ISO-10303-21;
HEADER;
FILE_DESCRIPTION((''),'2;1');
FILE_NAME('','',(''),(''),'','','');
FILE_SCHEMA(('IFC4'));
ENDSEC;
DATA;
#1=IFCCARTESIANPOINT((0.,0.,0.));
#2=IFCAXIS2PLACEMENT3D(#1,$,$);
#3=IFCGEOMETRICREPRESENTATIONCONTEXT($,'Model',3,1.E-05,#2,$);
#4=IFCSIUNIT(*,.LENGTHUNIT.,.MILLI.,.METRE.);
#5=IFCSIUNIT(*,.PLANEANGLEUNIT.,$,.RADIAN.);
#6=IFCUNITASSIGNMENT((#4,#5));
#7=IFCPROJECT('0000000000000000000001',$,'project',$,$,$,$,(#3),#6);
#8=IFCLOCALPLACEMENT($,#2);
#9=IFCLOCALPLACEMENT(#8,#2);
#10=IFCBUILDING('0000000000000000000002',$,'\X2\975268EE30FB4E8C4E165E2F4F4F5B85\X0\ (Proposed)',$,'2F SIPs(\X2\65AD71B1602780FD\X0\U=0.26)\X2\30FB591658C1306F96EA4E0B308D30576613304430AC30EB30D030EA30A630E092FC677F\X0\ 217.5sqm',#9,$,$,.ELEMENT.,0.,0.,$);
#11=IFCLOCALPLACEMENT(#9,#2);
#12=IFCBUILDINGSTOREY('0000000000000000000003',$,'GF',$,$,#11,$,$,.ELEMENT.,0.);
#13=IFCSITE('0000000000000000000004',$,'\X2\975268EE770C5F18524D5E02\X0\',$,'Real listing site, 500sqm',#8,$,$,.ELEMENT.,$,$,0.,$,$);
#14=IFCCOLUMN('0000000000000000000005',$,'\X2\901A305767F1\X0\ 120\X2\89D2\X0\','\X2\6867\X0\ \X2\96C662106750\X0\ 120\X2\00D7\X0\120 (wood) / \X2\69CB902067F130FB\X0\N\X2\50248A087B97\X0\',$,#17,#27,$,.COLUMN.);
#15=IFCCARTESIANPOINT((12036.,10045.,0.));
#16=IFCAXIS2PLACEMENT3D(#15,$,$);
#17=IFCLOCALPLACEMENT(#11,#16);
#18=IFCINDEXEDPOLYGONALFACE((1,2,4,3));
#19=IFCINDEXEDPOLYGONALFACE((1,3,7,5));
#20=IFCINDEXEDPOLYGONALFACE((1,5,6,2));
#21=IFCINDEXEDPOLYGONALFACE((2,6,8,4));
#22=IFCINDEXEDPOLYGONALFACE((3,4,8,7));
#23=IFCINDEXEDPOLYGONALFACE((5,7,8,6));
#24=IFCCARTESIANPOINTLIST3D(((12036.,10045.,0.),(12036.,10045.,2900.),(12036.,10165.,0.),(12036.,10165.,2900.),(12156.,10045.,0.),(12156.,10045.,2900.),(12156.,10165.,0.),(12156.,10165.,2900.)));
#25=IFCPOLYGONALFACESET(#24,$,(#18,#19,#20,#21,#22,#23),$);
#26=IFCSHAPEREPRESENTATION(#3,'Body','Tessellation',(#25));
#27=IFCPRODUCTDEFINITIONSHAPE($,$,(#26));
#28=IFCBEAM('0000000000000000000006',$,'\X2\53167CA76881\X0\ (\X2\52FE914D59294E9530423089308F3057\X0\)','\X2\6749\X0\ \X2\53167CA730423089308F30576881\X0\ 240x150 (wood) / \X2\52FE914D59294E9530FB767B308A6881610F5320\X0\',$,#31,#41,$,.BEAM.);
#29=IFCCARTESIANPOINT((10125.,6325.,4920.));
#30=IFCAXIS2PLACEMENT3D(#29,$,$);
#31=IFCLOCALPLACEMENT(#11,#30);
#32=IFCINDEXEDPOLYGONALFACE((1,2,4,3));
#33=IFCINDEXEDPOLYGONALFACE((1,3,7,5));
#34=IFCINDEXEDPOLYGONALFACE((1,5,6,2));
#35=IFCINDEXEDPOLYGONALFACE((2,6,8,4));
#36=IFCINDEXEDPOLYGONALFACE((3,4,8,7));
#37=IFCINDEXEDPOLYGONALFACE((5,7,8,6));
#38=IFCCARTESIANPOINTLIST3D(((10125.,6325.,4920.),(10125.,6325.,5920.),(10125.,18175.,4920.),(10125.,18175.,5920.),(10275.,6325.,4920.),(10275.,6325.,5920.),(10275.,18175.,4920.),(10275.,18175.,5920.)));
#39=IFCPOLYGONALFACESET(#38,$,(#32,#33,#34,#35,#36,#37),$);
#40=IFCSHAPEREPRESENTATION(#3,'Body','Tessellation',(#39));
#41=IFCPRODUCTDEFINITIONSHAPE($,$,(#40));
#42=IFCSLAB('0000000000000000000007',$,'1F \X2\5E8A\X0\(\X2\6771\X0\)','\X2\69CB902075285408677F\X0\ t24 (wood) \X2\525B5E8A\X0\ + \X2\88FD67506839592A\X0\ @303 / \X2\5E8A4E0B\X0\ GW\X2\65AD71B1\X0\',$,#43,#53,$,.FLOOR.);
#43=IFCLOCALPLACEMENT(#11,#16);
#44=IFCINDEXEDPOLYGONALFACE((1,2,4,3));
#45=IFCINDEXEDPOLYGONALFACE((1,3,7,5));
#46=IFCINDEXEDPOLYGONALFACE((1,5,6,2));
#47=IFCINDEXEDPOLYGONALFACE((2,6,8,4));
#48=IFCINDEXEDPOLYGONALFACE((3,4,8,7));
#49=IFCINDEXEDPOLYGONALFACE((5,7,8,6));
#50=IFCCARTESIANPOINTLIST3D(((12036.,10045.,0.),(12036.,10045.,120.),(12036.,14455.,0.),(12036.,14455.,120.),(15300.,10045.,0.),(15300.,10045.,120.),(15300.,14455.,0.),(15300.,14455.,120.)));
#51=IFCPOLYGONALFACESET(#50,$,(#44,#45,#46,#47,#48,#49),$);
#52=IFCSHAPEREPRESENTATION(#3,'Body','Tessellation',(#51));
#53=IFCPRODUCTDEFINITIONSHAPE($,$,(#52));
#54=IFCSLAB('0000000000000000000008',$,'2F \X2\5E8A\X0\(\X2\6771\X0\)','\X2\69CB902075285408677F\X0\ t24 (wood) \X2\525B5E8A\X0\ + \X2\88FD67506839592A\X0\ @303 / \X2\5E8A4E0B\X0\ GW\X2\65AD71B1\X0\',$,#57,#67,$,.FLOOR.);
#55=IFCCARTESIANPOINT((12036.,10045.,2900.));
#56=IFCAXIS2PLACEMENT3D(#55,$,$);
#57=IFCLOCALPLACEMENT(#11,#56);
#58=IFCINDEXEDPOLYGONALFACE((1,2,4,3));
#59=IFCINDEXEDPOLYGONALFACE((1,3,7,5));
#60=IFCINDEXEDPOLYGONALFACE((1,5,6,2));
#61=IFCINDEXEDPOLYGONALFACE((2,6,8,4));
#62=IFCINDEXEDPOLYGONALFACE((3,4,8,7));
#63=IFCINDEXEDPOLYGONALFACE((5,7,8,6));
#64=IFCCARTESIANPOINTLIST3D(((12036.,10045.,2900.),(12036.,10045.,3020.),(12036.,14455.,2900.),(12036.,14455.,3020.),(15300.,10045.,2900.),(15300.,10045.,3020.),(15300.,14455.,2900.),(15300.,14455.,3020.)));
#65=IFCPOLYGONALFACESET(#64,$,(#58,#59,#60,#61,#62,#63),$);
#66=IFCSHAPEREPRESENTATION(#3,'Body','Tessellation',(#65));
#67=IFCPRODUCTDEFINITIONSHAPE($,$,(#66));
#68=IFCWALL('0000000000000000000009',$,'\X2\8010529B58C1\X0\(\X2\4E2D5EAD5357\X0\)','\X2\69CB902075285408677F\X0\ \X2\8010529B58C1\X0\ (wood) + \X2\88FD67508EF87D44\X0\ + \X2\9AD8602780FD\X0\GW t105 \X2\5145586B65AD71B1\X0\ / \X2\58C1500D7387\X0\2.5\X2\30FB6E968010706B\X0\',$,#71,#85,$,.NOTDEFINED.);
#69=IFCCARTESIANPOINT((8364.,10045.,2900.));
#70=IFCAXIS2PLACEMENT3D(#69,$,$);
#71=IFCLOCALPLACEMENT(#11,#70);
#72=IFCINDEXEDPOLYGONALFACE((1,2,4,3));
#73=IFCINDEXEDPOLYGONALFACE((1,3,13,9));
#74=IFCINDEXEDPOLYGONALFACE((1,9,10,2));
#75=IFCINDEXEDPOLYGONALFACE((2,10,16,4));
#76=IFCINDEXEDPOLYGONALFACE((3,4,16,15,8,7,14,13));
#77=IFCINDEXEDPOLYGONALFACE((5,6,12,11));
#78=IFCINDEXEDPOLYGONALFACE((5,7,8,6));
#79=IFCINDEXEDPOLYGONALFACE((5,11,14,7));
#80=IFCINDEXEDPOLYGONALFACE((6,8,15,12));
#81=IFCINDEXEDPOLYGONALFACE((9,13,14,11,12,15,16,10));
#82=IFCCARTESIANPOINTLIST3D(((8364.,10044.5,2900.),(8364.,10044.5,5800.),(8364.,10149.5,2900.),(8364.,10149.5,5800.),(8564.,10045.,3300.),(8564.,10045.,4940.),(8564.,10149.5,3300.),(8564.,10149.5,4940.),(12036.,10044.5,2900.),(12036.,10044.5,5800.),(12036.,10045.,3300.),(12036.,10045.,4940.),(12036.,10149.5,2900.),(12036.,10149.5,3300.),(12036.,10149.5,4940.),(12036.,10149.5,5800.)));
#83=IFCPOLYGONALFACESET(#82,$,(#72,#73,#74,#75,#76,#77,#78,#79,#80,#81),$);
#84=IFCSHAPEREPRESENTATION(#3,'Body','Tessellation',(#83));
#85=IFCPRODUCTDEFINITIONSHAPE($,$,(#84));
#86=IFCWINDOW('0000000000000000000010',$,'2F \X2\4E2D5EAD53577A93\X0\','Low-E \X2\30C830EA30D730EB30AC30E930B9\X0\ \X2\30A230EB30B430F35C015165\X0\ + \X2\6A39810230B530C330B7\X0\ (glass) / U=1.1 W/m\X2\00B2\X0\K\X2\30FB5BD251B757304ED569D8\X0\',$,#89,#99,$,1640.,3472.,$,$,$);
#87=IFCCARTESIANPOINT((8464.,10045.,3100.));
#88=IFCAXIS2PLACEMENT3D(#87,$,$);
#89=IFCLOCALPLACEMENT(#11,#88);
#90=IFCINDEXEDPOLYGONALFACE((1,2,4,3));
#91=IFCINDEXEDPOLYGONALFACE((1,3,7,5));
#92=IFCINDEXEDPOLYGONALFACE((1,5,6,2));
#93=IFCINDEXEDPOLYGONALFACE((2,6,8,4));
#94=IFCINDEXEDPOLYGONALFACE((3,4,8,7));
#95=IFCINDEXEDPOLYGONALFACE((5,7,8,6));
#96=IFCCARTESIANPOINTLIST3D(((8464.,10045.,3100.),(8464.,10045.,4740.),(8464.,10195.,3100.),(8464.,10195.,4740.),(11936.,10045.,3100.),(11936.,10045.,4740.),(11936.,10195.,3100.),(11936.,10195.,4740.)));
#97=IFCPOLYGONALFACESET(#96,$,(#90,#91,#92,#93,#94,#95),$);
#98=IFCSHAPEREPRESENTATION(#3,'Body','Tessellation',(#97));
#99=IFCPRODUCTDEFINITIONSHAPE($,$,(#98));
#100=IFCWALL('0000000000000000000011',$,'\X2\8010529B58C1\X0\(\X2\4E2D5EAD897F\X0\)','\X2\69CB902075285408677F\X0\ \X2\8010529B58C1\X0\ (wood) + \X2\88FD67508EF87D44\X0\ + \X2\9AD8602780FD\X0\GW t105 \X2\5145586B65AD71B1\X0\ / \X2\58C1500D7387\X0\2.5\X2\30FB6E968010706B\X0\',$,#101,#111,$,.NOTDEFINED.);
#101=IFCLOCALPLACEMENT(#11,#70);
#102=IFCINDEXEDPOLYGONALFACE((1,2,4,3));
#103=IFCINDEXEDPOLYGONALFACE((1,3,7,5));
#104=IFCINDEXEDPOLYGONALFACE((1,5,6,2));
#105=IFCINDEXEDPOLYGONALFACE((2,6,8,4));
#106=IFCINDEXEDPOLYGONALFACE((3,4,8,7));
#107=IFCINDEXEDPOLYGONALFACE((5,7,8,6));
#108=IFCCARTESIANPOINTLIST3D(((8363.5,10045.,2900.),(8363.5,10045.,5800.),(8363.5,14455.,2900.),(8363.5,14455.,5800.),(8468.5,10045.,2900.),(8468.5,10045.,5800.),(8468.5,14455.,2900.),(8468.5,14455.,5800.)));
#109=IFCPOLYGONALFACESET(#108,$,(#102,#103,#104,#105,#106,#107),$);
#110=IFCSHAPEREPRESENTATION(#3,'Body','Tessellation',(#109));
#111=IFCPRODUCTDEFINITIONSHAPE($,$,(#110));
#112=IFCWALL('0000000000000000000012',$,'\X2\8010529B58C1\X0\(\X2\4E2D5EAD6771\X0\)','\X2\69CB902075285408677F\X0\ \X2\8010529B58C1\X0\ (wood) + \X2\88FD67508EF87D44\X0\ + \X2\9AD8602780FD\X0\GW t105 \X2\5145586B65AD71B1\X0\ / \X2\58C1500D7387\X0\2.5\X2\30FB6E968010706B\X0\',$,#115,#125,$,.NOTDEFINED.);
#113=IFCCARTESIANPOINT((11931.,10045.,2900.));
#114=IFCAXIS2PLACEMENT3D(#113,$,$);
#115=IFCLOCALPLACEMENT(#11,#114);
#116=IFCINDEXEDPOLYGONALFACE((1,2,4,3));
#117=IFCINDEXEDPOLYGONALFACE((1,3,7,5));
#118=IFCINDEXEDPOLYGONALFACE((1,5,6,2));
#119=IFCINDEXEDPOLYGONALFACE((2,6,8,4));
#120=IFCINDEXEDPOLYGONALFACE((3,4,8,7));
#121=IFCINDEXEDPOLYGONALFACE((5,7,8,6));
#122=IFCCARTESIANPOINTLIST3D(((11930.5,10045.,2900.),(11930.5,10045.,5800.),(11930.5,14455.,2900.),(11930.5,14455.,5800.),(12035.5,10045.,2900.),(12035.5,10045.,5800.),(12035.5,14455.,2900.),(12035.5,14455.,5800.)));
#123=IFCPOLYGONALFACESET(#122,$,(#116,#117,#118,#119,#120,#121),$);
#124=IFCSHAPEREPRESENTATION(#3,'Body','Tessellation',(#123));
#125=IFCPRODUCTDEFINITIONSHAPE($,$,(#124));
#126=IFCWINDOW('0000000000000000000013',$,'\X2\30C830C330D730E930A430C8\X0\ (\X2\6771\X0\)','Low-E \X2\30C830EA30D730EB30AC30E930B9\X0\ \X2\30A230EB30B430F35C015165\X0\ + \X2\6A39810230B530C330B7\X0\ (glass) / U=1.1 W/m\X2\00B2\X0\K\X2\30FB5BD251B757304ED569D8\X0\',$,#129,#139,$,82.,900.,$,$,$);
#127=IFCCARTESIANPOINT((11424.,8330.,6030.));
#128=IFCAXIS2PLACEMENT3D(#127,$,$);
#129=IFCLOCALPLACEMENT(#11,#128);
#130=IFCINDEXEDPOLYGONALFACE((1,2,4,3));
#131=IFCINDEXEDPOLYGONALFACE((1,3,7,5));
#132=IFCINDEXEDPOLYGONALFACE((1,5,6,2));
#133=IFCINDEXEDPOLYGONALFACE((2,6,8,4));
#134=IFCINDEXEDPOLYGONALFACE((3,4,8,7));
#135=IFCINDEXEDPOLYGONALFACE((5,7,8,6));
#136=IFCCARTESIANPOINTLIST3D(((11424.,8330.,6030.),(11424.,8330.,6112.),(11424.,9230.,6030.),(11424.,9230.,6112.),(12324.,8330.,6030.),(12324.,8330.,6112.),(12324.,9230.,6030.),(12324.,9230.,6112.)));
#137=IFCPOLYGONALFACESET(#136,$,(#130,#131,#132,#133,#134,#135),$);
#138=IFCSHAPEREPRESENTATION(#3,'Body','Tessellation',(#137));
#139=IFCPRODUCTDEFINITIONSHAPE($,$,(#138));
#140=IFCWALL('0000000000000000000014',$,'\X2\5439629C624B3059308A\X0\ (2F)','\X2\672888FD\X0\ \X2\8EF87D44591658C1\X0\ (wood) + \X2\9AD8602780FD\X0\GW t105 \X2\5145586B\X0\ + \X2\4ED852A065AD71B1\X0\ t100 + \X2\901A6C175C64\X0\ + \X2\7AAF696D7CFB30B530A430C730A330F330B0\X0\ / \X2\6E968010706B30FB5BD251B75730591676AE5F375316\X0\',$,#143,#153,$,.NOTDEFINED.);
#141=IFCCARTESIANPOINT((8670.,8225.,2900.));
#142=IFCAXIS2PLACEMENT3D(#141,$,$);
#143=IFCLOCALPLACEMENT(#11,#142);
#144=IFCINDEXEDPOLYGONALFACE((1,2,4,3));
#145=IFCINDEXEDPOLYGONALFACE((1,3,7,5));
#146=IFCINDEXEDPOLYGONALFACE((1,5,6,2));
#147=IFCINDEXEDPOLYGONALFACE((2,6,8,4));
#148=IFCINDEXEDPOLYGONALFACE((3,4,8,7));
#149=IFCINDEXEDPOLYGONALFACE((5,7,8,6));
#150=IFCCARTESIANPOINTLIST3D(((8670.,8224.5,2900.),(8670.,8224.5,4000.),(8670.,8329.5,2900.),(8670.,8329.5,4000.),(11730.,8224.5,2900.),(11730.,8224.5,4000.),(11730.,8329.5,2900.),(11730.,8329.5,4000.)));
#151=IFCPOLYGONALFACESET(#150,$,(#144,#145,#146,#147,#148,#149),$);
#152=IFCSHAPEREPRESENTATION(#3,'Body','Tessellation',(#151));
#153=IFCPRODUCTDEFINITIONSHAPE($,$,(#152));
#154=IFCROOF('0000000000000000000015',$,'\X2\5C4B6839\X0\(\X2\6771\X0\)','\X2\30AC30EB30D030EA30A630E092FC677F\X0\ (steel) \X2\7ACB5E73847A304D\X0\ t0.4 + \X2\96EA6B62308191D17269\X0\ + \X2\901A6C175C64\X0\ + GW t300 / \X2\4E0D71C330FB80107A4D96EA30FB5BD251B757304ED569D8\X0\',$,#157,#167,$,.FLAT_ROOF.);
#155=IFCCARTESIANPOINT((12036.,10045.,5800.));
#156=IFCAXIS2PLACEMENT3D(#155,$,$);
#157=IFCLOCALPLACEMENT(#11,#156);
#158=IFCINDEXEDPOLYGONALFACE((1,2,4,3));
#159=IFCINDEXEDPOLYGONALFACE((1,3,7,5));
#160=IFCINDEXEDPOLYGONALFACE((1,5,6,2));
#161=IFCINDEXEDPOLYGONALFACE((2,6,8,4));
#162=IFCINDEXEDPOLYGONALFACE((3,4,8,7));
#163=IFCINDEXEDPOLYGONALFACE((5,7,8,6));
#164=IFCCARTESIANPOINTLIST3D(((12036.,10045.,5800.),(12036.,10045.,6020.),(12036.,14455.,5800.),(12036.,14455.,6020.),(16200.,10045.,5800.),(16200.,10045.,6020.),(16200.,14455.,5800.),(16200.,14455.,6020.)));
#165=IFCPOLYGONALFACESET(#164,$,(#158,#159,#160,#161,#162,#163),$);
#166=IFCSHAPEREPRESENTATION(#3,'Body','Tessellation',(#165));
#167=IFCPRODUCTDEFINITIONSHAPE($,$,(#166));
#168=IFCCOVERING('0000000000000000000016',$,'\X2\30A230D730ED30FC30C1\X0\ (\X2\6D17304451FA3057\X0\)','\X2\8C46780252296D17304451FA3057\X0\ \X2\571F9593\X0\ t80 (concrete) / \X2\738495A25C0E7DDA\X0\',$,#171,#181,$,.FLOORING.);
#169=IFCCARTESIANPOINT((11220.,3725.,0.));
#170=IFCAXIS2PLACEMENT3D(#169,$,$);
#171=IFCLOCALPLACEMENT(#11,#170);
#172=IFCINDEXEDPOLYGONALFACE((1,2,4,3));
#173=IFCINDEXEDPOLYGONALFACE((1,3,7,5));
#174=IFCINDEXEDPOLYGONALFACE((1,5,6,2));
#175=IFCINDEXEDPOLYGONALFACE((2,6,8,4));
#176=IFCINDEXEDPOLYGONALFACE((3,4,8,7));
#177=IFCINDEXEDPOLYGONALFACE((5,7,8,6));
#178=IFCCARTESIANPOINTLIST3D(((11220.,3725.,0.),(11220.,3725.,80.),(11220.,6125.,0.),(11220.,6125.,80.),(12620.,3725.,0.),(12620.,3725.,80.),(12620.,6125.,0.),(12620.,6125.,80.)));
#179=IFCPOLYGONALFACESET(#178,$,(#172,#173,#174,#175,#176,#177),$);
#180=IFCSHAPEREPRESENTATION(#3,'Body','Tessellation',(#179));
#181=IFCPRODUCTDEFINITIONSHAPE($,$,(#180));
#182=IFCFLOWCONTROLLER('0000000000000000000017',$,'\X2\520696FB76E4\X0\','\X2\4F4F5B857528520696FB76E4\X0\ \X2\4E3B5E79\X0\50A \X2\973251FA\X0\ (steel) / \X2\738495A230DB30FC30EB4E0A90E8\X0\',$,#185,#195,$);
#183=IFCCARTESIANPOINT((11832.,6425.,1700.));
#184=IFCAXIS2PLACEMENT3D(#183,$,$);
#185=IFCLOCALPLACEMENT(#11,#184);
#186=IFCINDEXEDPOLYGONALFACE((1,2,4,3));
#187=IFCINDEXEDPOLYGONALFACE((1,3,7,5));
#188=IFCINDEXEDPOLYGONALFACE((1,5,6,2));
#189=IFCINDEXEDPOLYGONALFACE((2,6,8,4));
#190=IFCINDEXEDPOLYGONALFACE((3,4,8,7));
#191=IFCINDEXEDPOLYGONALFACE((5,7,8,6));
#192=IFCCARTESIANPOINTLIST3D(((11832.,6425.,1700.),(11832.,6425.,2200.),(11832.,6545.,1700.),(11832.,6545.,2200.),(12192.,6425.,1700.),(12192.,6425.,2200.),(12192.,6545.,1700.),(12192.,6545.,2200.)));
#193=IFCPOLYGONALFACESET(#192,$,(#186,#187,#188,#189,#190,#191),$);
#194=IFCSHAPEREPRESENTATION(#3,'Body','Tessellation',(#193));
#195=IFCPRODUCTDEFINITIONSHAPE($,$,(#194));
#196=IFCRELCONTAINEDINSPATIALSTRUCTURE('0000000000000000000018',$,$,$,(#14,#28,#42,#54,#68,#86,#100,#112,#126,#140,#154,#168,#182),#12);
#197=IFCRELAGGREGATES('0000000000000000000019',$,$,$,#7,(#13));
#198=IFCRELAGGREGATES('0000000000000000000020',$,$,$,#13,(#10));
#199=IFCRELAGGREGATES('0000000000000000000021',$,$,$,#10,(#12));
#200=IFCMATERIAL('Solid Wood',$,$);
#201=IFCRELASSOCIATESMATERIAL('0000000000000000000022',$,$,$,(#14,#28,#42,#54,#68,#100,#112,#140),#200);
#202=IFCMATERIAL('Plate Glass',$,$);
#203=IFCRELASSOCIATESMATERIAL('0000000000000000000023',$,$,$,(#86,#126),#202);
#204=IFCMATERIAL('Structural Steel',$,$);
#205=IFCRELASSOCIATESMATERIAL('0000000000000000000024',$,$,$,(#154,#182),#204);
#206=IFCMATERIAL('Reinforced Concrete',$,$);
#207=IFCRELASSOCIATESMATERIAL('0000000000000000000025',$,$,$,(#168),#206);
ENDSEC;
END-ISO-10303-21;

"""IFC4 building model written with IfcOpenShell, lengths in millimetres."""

from ifc_helpers import new_model, si_unit, frame, frame_2d, origin, place, context, project, spatial, rectangle, extrude, material, element, fill, save


model = new_model("IFC4")

# Units and contexts
model_context = context("Model", 3, precision=1e-05, world=origin())
ifc_project = project(units=[si_unit("LENGTHUNIT", "METRE", prefix="MILLI"), si_unit("PLANEANGLEUNIT", "RADIAN")], contexts=[model_context])

# Site, building, storey
site_placement = place(None, origin())
site = spatial("IfcSite", under=ifc_project, at=site_placement, Name="青森県弘前市", ObjectType="Real listing site, 500sqm", CompositionType="ELEMENT", RefElevation=0.0)
building_placement = place(site_placement, origin())
building = spatial("IfcBuilding", under=site, at=building_placement, Name="青森・二世帯住宅 (Proposed)", ObjectType="2F SIPs(断熱性能U=0.26)・外壁は雪下ろし易いガルバリウム鋼板 217.5sqm", CompositionType="ELEMENT", ElevationOfRefHeight=0.0, ElevationOfTerrain=0.0)
storey_placement = place(building_placement, origin())
storey = spatial("IfcBuildingStorey", under=building, at=storey_placement, Name="GF", CompositionType="ELEMENT", Elevation=0.0)

# Column
ifc_material_1 = material(Name="Solid Wood")
column_1_placement = place(storey_placement, frame((12036.0, 10045.0, 0.0)))
element("IfcColumn", 1, at=column_1_placement, inside=storey, material=ifc_material_1, Name="通し柱 120角", Description="桧 集成材 120×120 (wood) / 構造柱・N値計算", PredefinedType="COLUMN", context=model_context, shape_type="SweptSolid", body=[
    extrude(rectangle(XDim=120.0, YDim=120.0, at=frame_2d((60.0, 60.0))), frame((12036.0, 10045.0, 0.0)), (0.0, 0.0, 1.0), 2900.0),
])

# Beam
beam_placement = place(storey_placement, frame((10125.0, 6325.0, 4920.0)))
element("IfcBeam", 2, at=beam_placement, inside=storey, material=ifc_material_1, Name="化粧梁 (勾配天井あらわし)", Description="杉 化粧あらわし梁 240x150 (wood) / 勾配天井・登り梁意匠", PredefinedType="BEAM", context=model_context, shape_type="SweptSolid", body=[
    extrude(rectangle(XDim=150.0, YDim=11850.0, at=frame_2d((75.0, 5925.0))), frame((10125.0, 6325.0, 4920.0)), (0.0, 0.0, 1.0), 1000.0),
])

# Slabs
slab_1_placement = place(storey_placement, frame((12036.0, 10045.0, 0.0)))
element("IfcSlab", 3, at=slab_1_placement, inside=storey, material=ifc_material_1, Name="1F 床(東)", Description="構造用合板 t24 (wood) 剛床 + 製材根太 @303 / 床下 GW断熱", PredefinedType="FLOOR", context=model_context, shape_type="SweptSolid", body=[
    extrude(rectangle(XDim=3264.0, YDim=4410.0, at=frame_2d((1632.0, 2205.0))), frame((12036.0, 10045.0, 0.0)), (0.0, 0.0, 1.0), 120.0),
])
slab_2_placement = place(storey_placement, frame((12036.0, 10045.0, 2900.0)))
element("IfcSlab", 4, at=slab_2_placement, inside=storey, material=ifc_material_1, Name="2F 床(東)", Description="構造用合板 t24 (wood) 剛床 + 製材根太 @303 / 床下 GW断熱", PredefinedType="FLOOR", context=model_context, shape_type="SweptSolid", body=[
    extrude(rectangle(XDim=3264.0, YDim=4410.0, at=frame_2d((1632.0, 2205.0))), frame((12036.0, 10045.0, 2900.0)), (0.0, 0.0, 1.0), 120.0),
])

# Wall, opening, window
wall_1_placement = place(storey_placement, frame((8364.0, 10045.0, 2900.0)))
wall_1 = element("IfcWall", 5, at=wall_1_placement, inside=storey, material=ifc_material_1, Name="耐力壁(中庭南)", Description="構造用合板 耐力壁 (wood) + 製材軸組 + 高性能GW t105 充填断熱 / 壁倍率2.5・準耐火", PredefinedType="NOTDEFINED", context=model_context, shape_type="SweptSolid", body=[
    extrude(rectangle(XDim=3672.0, YDim=105.0, at=frame_2d((1836.0, 52.0))), frame((8364.0, 10045.0, 2900.0)), (0.0, 0.0, 1.0), 2900.0),
])
opening_placement = place(storey_placement, frame((8464.0, 10045.0, 3100.0)))
opening = element("IfcOpeningElement", 6, at=opening_placement, cuts=wall_1, PredefinedType="NOTDEFINED", context=model_context, shape_type="SweptSolid", body=[
    extrude(rectangle(XDim=3472.0, YDim=150.0, at=frame_2d((1736.0, 75.0))), frame((8464.0, 10045.0, 3100.0)), (0.0, 0.0, 1.0), 1640.0),
])
ifc_material_2 = material(Name="Plate Glass")
window_1_placement = place(storey_placement, frame((8464.0, 10045.0, 3100.0)))
window_1 = element("IfcWindow", 7, at=window_1_placement, inside=storey, material=ifc_material_2, Name="2F 中庭南窓", Description="Low-E トリプルガラス アルゴン封入 + 樹脂サッシ (glass) / U=1.1 W/m²K・寒冷地仕様", OverallHeight=1640.0, OverallWidth=3472.0, context=model_context, shape_type="SweptSolid", body=[
    extrude(rectangle(XDim=3472.0, YDim=150.0, at=frame_2d((1736.0, 75.0))), frame((8464.0, 10045.0, 3100.0)), (0.0, 0.0, 1.0), 1640.0),
])
fill(opening, window_1)

# Walls
wall_2_placement = place(storey_placement, frame((8364.0, 10045.0, 2900.0)))
element("IfcWall", 8, at=wall_2_placement, inside=storey, material=ifc_material_1, Name="耐力壁(中庭西)", Description="構造用合板 耐力壁 (wood) + 製材軸組 + 高性能GW t105 充填断熱 / 壁倍率2.5・準耐火", PredefinedType="NOTDEFINED", context=model_context, shape_type="SweptSolid", body=[
    extrude(rectangle(XDim=105.0, YDim=4410.0, at=frame_2d((52.0, 2205.0))), frame((8364.0, 10045.0, 2900.0)), (0.0, 0.0, 1.0), 2900.0),
])
wall_3_placement = place(storey_placement, frame((11931.0, 10045.0, 2900.0)))
element("IfcWall", 9, at=wall_3_placement, inside=storey, material=ifc_material_1, Name="耐力壁(中庭東)", Description="構造用合板 耐力壁 (wood) + 製材軸組 + 高性能GW t105 充填断熱 / 壁倍率2.5・準耐火", PredefinedType="NOTDEFINED", context=model_context, shape_type="SweptSolid", body=[
    extrude(rectangle(XDim=105.0, YDim=4410.0, at=frame_2d((52.0, 2205.0))), frame((11931.0, 10045.0, 2900.0)), (0.0, 0.0, 1.0), 2900.0),
])

# Window
window_2_placement = place(storey_placement, frame((11424.0, 8330.0, 6030.0)))
element("IfcWindow", 10, at=window_2_placement, inside=storey, material=ifc_material_2, Name="トップライト (東)", Description="Low-E トリプルガラス アルゴン封入 + 樹脂サッシ (glass) / U=1.1 W/m²K・寒冷地仕様", OverallHeight=82.0, OverallWidth=900.0, context=model_context, shape_type="SweptSolid", body=[
    extrude(rectangle(XDim=900.0, YDim=900.0, at=frame_2d((450.0, 450.0))), frame((11424.0, 8330.0, 6030.0)), (0.0, 0.0, 1.0), 82.0),
])

# Wall
wall_4_placement = place(storey_placement, frame((8670.0, 8225.0, 2900.0)))
element("IfcWall", 11, at=wall_4_placement, inside=storey, material=ifc_material_1, Name="吹抜手すり (2F)", Description="木製 軸組外壁 (wood) + 高性能GW t105 充填 + 付加断熱 t100 + 通気層 + 窯業系サイディング / 準耐火・寒冷地外皮強化", PredefinedType="NOTDEFINED", context=model_context, shape_type="SweptSolid", body=[
    extrude(rectangle(XDim=3060.0, YDim=105.0, at=frame_2d((1530.0, 52.0))), frame((8670.0, 8225.0, 2900.0)), (0.0, 0.0, 1.0), 1100.0),
])

# Roof
ifc_material_3 = material(Name="Structural Steel")
for number, where, name in (
    (12, (12036.0, 10045.0, 5800.0), "屋根(東)"),
):
    element("IfcRoof", number, at=place(storey_placement, frame(where)), inside=storey, material=ifc_material_3, Name=name, Description="ガルバリウム鋼板 (steel) 立平葺き t0.4 + 雪止め金物 + 通気層 + GW t300 / 不燃・耐積雪・寒冷地仕様", PredefinedType="FLAT_ROOF", context=model_context, shape_type="SweptSolid", body=[
        extrude(rectangle(XDim=4164.0, YDim=4410.0, at=frame_2d((2082.0, 2205.0))), frame((12036.0, 10045.0, 5800.0)), (0.0, 0.0, 1.0), 220.0),
    ])

# Covering
ifc_material_4 = material(Name="Reinforced Concrete")
covering_placement = place(storey_placement, frame((11220.0, 3725.0, 0.0)))
element("IfcCovering", 13, at=covering_placement, inside=storey, material=ifc_material_4, Name="アプローチ (洗い出し)", Description="豆砂利洗い出し 土間 t80 (concrete) / 玄関導線", PredefinedType="FLOORING", context=model_context, shape_type="SweptSolid", body=[
    extrude(rectangle(XDim=1400.0, YDim=2400.0, at=frame_2d((700.0, 1200.0))), frame((11220.0, 3725.0, 0.0)), (0.0, 0.0, 1.0), 80.0),
])

# Flow controller
flow_controller_placement = place(storey_placement, frame((11832.0, 6425.0, 1700.0)))
element("IfcFlowController", 14, at=flow_controller_placement, inside=storey, material=ifc_material_3, Name="分電盤", Description="住宅用分電盤 主幹50A 露出 (steel) / 玄関ホール上部", context=model_context, shape_type="SweptSolid", body=[
    extrude(rectangle(XDim=360.0, YDim=120.0, at=frame_2d((180.0, 60.0))), frame((11832.0, 6425.0, 1700.0)), (0.0, 0.0, 1.0), 500.0),
])

save(model, "model.ifc")
